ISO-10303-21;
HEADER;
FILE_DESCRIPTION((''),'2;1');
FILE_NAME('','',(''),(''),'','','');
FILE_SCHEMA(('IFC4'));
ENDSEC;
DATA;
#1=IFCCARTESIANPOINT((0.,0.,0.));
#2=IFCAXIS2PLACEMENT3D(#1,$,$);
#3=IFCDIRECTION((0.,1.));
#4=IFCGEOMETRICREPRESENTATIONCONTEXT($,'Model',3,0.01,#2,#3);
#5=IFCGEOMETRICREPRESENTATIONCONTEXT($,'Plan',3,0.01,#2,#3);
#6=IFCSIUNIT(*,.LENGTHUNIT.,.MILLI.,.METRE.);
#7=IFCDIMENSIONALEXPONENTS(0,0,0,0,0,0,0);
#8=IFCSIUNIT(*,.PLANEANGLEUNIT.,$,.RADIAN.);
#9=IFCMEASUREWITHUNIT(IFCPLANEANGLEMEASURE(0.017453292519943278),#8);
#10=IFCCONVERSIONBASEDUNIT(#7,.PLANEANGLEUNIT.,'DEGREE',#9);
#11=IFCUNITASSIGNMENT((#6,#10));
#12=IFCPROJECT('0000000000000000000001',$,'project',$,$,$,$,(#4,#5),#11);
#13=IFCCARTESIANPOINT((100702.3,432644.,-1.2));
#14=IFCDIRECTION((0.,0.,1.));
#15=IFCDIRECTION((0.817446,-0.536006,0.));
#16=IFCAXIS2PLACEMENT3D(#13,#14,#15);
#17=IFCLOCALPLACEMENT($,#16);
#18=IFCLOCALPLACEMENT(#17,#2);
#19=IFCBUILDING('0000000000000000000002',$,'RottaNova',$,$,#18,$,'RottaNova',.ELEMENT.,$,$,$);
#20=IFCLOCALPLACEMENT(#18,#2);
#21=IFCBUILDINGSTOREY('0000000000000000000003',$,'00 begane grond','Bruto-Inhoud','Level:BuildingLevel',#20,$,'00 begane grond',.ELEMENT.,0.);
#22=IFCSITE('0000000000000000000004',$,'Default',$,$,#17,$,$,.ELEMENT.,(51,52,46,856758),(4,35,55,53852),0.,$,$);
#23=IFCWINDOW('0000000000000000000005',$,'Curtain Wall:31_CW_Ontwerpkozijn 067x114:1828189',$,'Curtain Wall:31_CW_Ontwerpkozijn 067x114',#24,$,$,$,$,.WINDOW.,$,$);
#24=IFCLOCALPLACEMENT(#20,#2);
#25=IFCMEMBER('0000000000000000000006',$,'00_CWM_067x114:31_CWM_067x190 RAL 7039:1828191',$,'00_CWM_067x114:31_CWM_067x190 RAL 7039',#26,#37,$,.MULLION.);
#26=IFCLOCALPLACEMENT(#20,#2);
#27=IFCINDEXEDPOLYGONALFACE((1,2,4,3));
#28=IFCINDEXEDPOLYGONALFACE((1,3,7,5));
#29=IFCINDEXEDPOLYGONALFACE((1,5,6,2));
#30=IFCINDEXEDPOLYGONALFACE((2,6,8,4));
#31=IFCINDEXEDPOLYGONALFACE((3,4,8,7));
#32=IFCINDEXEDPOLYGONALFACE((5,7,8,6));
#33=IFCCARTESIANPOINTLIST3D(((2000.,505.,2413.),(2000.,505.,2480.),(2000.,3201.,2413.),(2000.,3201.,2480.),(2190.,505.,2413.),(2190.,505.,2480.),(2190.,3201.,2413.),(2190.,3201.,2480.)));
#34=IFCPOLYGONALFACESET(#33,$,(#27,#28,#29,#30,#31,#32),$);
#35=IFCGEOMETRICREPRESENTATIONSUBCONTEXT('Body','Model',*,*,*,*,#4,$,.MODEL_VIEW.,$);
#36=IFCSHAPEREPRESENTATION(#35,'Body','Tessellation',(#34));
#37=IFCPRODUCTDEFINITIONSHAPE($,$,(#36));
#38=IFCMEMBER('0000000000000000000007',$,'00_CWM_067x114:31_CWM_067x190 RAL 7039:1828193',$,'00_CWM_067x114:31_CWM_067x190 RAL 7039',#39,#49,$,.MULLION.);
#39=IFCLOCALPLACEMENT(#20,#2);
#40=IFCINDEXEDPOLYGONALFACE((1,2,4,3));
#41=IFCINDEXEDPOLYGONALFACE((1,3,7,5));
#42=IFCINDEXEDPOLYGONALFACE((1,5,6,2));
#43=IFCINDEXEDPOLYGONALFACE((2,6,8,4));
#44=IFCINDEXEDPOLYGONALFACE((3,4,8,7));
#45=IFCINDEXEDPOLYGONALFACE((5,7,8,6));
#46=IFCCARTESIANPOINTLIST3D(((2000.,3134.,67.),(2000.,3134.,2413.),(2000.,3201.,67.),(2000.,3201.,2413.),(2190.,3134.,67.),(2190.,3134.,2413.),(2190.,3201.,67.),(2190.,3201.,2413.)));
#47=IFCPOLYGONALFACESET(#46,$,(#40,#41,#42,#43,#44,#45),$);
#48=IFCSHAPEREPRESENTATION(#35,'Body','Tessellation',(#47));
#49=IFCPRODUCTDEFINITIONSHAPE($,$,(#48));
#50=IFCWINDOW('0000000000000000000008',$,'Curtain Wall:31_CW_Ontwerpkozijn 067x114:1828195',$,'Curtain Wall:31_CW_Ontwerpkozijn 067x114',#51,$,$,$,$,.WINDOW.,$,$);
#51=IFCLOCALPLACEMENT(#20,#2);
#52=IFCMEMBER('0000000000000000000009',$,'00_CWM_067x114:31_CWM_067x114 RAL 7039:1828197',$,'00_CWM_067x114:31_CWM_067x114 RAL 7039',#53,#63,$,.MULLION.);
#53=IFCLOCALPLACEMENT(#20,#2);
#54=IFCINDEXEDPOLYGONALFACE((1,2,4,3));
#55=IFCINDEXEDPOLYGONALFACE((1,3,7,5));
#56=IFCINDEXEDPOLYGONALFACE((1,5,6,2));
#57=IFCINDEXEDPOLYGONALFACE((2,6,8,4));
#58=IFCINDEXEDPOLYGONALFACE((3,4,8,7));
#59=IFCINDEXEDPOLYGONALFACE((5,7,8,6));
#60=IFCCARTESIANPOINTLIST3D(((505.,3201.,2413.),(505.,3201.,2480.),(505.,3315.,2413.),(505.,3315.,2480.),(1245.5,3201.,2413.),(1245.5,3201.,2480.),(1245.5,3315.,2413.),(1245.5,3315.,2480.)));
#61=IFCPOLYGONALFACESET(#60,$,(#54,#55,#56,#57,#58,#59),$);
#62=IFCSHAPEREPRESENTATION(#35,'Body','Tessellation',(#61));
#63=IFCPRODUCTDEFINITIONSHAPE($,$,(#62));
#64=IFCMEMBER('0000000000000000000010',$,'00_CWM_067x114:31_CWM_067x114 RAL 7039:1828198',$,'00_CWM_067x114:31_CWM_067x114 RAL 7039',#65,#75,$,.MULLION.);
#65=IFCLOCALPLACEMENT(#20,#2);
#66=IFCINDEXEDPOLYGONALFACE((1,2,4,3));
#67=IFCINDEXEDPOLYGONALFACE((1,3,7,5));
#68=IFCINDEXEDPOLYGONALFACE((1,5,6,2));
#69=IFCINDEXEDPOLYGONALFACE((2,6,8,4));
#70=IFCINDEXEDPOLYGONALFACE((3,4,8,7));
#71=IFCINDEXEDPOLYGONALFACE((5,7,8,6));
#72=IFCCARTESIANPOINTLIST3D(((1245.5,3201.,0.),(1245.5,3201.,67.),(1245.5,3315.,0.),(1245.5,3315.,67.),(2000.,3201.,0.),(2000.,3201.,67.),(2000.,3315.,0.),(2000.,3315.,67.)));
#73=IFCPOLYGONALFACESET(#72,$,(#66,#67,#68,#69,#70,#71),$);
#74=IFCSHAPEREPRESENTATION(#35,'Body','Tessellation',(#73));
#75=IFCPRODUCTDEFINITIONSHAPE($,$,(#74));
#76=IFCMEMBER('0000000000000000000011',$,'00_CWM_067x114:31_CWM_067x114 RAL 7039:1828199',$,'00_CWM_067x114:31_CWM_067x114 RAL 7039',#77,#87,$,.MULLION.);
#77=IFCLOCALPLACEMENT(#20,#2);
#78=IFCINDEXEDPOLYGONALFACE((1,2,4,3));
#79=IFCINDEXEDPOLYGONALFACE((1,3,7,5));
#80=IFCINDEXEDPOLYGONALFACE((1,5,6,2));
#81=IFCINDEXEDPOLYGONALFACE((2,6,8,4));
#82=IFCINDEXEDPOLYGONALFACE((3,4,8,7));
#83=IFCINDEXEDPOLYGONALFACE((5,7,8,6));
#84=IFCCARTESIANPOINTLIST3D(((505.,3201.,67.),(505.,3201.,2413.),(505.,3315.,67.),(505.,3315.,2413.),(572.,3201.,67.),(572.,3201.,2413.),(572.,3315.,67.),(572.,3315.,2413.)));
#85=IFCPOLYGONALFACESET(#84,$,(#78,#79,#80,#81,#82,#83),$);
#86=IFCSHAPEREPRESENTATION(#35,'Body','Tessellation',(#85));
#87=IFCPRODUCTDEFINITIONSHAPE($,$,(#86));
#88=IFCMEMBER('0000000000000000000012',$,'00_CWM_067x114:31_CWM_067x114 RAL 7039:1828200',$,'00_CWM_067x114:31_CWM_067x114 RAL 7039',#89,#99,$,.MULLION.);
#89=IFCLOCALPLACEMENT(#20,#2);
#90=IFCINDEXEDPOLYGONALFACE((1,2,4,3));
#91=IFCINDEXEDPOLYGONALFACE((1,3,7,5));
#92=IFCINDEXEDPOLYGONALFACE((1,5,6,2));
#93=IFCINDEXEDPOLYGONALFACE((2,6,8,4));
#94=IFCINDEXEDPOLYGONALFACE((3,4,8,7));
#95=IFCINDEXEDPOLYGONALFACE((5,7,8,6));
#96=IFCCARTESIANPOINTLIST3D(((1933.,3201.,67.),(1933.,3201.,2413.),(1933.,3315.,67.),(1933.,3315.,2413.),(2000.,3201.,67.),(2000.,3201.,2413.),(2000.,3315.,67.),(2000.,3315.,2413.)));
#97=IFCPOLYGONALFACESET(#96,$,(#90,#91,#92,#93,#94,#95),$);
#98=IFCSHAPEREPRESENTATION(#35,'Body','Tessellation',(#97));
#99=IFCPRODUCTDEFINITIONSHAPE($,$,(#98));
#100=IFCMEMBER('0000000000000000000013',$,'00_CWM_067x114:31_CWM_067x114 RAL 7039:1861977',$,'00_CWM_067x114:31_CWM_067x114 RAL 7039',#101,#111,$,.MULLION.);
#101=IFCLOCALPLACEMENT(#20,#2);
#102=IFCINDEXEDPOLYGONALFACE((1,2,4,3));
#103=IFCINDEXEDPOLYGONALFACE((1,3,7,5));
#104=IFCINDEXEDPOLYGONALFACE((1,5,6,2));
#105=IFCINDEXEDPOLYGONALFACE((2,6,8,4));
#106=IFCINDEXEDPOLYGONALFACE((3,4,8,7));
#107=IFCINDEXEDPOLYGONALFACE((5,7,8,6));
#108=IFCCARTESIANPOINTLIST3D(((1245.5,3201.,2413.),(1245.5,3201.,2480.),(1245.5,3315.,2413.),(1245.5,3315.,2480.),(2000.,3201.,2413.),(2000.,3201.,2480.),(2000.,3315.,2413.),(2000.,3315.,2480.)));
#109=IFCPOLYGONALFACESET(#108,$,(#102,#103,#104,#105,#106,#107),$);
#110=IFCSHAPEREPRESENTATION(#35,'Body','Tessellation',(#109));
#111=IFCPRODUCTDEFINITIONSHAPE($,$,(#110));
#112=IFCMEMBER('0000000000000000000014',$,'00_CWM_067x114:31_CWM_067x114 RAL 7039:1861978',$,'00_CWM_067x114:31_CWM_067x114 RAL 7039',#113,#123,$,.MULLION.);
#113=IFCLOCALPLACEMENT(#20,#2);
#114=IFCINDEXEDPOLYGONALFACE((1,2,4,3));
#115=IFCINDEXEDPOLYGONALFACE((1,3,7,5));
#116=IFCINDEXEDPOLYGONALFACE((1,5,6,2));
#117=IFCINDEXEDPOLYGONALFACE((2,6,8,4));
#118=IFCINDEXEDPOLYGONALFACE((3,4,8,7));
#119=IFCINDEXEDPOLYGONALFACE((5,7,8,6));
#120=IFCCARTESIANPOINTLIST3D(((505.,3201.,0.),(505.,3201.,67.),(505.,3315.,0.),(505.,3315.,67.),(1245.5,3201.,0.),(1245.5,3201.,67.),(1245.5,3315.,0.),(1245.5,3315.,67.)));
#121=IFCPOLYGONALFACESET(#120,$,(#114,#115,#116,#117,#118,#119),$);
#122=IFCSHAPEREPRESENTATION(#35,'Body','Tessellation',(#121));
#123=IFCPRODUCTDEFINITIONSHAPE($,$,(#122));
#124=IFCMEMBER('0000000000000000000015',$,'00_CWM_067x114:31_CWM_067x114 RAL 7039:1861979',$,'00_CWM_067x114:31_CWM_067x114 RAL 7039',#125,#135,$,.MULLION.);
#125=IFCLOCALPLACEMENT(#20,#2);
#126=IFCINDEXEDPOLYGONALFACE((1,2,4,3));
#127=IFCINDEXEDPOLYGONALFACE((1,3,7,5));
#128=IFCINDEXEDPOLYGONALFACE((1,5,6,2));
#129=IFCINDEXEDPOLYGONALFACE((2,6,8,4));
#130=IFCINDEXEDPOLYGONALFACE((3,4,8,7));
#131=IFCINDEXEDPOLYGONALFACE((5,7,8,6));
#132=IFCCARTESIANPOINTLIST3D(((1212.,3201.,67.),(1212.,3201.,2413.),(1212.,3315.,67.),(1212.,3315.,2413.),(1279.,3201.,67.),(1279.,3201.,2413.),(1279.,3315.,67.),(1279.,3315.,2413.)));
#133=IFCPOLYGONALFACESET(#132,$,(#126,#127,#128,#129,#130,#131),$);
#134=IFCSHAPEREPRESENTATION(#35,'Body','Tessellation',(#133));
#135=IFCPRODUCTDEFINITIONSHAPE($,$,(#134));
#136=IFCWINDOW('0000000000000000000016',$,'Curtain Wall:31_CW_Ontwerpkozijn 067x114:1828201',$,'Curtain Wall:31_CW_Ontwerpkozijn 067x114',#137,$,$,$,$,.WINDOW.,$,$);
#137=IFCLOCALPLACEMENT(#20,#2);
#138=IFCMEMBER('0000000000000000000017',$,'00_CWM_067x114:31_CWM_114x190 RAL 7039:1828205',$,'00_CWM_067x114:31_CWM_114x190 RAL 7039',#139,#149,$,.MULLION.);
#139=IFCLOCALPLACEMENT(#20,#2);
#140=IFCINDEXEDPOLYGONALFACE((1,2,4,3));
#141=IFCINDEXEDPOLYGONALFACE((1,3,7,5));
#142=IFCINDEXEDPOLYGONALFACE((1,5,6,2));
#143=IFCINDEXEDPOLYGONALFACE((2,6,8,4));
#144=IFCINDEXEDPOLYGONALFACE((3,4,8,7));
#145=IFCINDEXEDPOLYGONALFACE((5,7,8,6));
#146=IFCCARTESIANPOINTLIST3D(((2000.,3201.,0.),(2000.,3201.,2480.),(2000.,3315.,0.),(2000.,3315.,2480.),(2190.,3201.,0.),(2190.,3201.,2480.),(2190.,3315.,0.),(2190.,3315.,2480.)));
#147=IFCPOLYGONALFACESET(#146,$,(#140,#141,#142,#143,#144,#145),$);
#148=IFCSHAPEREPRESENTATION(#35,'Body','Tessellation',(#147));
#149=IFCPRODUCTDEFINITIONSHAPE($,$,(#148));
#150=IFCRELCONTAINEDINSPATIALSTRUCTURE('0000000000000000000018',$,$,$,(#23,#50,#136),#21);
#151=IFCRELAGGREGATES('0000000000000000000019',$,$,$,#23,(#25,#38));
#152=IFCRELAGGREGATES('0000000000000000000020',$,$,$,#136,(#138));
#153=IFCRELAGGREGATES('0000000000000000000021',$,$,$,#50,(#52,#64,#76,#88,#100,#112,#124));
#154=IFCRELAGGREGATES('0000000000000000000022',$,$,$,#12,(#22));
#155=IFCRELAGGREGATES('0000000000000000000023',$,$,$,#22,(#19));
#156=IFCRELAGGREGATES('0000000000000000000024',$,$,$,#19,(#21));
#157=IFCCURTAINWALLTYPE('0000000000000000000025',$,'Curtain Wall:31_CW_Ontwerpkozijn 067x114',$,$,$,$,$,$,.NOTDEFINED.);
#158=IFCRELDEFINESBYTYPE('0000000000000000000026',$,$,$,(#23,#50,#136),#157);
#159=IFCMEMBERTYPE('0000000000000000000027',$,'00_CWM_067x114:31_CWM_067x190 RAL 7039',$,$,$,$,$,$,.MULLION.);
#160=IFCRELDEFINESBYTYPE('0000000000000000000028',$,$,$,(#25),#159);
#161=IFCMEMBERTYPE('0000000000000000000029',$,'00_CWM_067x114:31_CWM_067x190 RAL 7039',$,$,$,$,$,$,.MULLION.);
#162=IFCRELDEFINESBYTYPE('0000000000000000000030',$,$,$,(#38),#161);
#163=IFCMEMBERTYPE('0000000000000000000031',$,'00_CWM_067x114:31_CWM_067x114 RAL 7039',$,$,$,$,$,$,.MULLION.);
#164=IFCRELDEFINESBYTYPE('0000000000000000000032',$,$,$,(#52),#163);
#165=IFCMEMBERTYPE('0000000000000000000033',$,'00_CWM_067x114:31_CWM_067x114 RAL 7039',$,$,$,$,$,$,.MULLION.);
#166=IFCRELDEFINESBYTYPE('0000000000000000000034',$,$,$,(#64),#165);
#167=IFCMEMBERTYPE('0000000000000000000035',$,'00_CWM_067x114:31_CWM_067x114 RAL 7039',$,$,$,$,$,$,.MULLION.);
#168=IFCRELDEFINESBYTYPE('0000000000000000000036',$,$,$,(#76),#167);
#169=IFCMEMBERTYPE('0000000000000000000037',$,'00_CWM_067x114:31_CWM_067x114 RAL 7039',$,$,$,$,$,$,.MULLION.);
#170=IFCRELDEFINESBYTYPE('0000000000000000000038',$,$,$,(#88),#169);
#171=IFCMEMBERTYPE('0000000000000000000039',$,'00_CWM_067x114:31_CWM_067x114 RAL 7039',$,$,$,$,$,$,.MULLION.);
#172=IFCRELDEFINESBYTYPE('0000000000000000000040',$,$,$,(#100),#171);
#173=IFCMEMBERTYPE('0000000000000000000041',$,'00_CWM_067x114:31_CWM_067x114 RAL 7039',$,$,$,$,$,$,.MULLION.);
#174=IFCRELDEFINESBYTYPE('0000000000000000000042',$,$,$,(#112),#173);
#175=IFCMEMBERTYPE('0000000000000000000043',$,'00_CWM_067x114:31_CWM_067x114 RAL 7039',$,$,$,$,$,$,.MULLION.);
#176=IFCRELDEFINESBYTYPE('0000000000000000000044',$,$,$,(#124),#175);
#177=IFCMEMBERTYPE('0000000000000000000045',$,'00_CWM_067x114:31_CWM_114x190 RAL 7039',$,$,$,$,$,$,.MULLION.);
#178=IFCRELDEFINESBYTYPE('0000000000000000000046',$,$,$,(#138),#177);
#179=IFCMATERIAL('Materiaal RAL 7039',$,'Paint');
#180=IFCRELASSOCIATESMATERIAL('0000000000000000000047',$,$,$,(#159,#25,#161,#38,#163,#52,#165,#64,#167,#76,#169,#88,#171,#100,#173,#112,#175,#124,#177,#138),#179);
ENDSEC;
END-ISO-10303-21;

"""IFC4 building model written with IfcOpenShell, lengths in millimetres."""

from ifc_helpers import new_model, entity, si_unit, converted_unit, direction, frame, origin, place, context, subcontext, project, spatial, indexed_curve, outline, extrude, source, transform, mapped, material, type_object, type_shapes, element, aggregate, save


model = new_model("IFC4")

# Units and contexts
model_context = context("Model", 3, precision=0.01, world=origin(), true_north=direction((0.0, 1.0)))
plan_context = context("Plan", 3, precision=0.01, world=origin(), true_north=direction((0.0, 1.0)))
body_context = subcontext(model_context, "Body", "Model", "MODEL_VIEW")
ifc_project = project(units=[si_unit("LENGTHUNIT", "METRE", prefix="MILLI"), converted_unit("PLANEANGLEUNIT", "DEGREE", entity("IfcPlaneAngleMeasure", 0.017453292519943278), si_unit("PLANEANGLEUNIT", "RADIAN"), dimensions=[0, 0, 0, 0, 0, 0, 0])], contexts=[model_context, plan_context])

# Site, building, storey
site_placement = place(None, frame((100702.3, 432644.0, -1.2), z_axis=(0.0, 0.0, 1.0), x_axis=(0.817446, -0.536006, 0.0)))
site = spatial("IfcSite", under=ifc_project, at=site_placement, Name="Default", CompositionType="ELEMENT", RefLatitude=(51, 52, 46, 856758), RefLongitude=(4, 35, 55, 53852), RefElevation=0.0)
building_placement = place(site_placement, origin())
building = spatial("IfcBuilding", under=site, at=building_placement, Name="RottaNova", LongName="RottaNova", CompositionType="ELEMENT")
storey_placement = place(building_placement, origin())
storey = spatial("IfcBuildingStorey", under=building, at=storey_placement, Name="00 begane grond", Description="Bruto-Inhoud", ObjectType="Level:BuildingLevel", LongName="00 begane grond", CompositionType="ELEMENT", Elevation=0.0)

# Windows, members
curtain_wall_type = type_object("IfcCurtainWallType", Name="Curtain Wall:31_CW_Ontwerpkozijn 067x114", PredefinedType="NOTDEFINED")
window_1_placement = place(storey_placement, origin())
window_1 = element("IfcWindow", 1, at=window_1_placement, inside=storey, type_object=curtain_wall_type, Name="Curtain Wall:31_CW_Ontwerpkozijn 067x114:1828189", ObjectType="Curtain Wall:31_CW_Ontwerpkozijn 067x114", PredefinedType="WINDOW")
ifc_material_1 = material(Name="Materiaal RAL 7039", Category="Paint")
member_type_1 = type_object("IfcMemberType", Name="00_CWM_067x114:31_CWM_067x190 RAL 7039", PredefinedType="MULLION", material=ifc_material_1)
shared_shape_1 = source(origin(), body_context, "Body", "SweptSolid", [
    extrude(outline(indexed_curve([(-33.5, -95.0), (33.5, -95.0), (33.5, 95.0), (-33.5, 95.0), (-33.5, -95.0)], self_intersect=False)), frame((-33.5, -95.0, -2696.0), z_axis=(0.0, 0.0, 1.0), x_axis=(-1.0, 0.0, 0.0)), (0.0, 0.0, 1.0), 2696.0),
])
type_shapes(member_type_1, [shared_shape_1])
member_1_placement = place(window_1_placement, frame((2190.0, 3201.0, 2480.0), z_axis=(0.0, 1.0, 0.0), x_axis=(0.0, 0.0, 1.0)))
member_1 = element("IfcMember", 2, at=member_1_placement, type_object=member_type_1, material=ifc_material_1, Name="00_CWM_067x114:31_CWM_067x190 RAL 7039:1828191", ObjectType="00_CWM_067x114:31_CWM_067x190 RAL 7039", PredefinedType="MULLION", context=body_context, shape_type="MappedRepresentation", body=[
    mapped(shared_shape_1, transform((0.0, 0.0, 0.0), scale=1.0)),
])
member_type_2 = type_object("IfcMemberType", Name="00_CWM_067x114:31_CWM_067x190 RAL 7039", PredefinedType="MULLION", material=ifc_material_1)
shared_shape_2 = source(origin(), body_context, "Body", "SweptSolid", [
    extrude(outline(indexed_curve([(-33.5, -95.0), (33.5, -95.0), (33.5, 95.0), (-33.5, 95.0), (-33.5, -95.0)], self_intersect=False)), frame((-33.5, -95.0, -2346.0), z_axis=(0.0, 0.0, 1.0), x_axis=(-1.0, 0.0, 0.0)), (0.0, 0.0, 1.0), 2346.0),
])
type_shapes(member_type_2, [shared_shape_2])
member_2_placement = place(window_1_placement, frame((2190.0, 3201.0, 67.0), z_axis=(0.0, 0.0, -1.0), x_axis=(0.0, 1.0, 0.0)))
member_2 = element("IfcMember", 3, at=member_2_placement, type_object=member_type_2, material=ifc_material_1, Name="00_CWM_067x114:31_CWM_067x190 RAL 7039:1828193", ObjectType="00_CWM_067x114:31_CWM_067x190 RAL 7039", PredefinedType="MULLION", context=body_context, shape_type="MappedRepresentation", body=[
    mapped(shared_shape_2, transform((0.0, 0.0, 0.0), scale=1.0)),
])
aggregate(window_1, [member_1, member_2])
window_2_placement = place(storey_placement, origin())
window_2 = element("IfcWindow", 4, at=window_2_placement, inside=storey, type_object=curtain_wall_type, Name="Curtain Wall:31_CW_Ontwerpkozijn 067x114:1828195", ObjectType="Curtain Wall:31_CW_Ontwerpkozijn 067x114", PredefinedType="WINDOW")
member_type_3 = type_object("IfcMemberType", Name="00_CWM_067x114:31_CWM_067x114 RAL 7039", PredefinedType="MULLION", material=ifc_material_1)
shared_shape_3 = source(origin(), body_context, "Body", "SweptSolid", [
    extrude(outline(indexed_curve([(-33.5, -57.0), (33.5, -57.0), (33.5, 57.0), (-33.5, 57.0), (-33.5, -57.0)], self_intersect=False)), frame((-33.5, -57.0, -740.5), z_axis=(0.0, 0.0, 1.0), x_axis=(-1.0, 0.0, 0.0)), (0.0, 0.0, 1.0), 740.5),
])
type_shapes(member_type_3, [shared_shape_3])
member_3_placement = place(window_2_placement, frame((505.0, 3315.0, 2480.0), z_axis=(-1.0, 0.0, 0.0), x_axis=(0.0, 0.0, 1.0)))
member_3 = element("IfcMember", 5, at=member_3_placement, type_object=member_type_3, material=ifc_material_1, Name="00_CWM_067x114:31_CWM_067x114 RAL 7039:1828197", ObjectType="00_CWM_067x114:31_CWM_067x114 RAL 7039", PredefinedType="MULLION", context=body_context, shape_type="MappedRepresentation", body=[
    mapped(shared_shape_3, transform((0.0, 0.0, 0.0), scale=1.0)),
])
member_type_4 = type_object("IfcMemberType", Name="00_CWM_067x114:31_CWM_067x114 RAL 7039", PredefinedType="MULLION", material=ifc_material_1)
shared_shape_4 = source(origin(), body_context, "Body", "SweptSolid", [
    extrude(outline(indexed_curve([(-33.5, -57.0), (33.5, -57.0), (33.5, 57.0), (-33.5, 57.0), (-33.5, -57.0)], self_intersect=False)), frame((-33.5, -57.0, -754.5), z_axis=(0.0, 0.0, 1.0), x_axis=(-1.0, 0.0, 0.0)), (0.0, 0.0, 1.0), 754.5),
])
type_shapes(member_type_4, [shared_shape_4])
member_4_placement = place(window_2_placement, frame((2000.0, 3315.0, 0.0), z_axis=(1.0, 0.0, 0.0), x_axis=(0.0, 0.0, -1.0)))
member_4 = element("IfcMember", 6, at=member_4_placement, type_object=member_type_4, material=ifc_material_1, Name="00_CWM_067x114:31_CWM_067x114 RAL 7039:1828198", ObjectType="00_CWM_067x114:31_CWM_067x114 RAL 7039", PredefinedType="MULLION", context=body_context, shape_type="MappedRepresentation", body=[
    mapped(shared_shape_4, transform((0.0, 0.0, 0.0), scale=1.0)),
])
member_type_5 = type_object("IfcMemberType", Name="00_CWM_067x114:31_CWM_067x114 RAL 7039", PredefinedType="MULLION", material=ifc_material_1)
shared_shape_5 = source(origin(), body_context, "Body", "SweptSolid", [
    extrude(outline(indexed_curve([(-33.5, -57.0), (33.5, -57.0), (33.5, 57.0), (-33.5, 57.0), (-33.5, -57.0)], self_intersect=False)), frame((-33.5, -57.0, -2346.0), z_axis=(0.0, 0.0, 1.0), x_axis=(-1.0, 0.0, 0.0)), (0.0, 0.0, 1.0), 2346.0),
])
type_shapes(member_type_5, [shared_shape_5])
member_5_placement = place(window_2_placement, frame((505.0, 3315.0, 67.0), z_axis=(0.0, 0.0, -1.0), x_axis=(-1.0, 0.0, 0.0)))
member_5 = element("IfcMember", 7, at=member_5_placement, type_object=member_type_5, material=ifc_material_1, Name="00_CWM_067x114:31_CWM_067x114 RAL 7039:1828199", ObjectType="00_CWM_067x114:31_CWM_067x114 RAL 7039", PredefinedType="MULLION", context=body_context, shape_type="MappedRepresentation", body=[
    mapped(shared_shape_5, transform((0.0, 0.0, 0.0), scale=1.0)),
])
member_type_6 = type_object("IfcMemberType", Name="00_CWM_067x114:31_CWM_067x114 RAL 7039", PredefinedType="MULLION", material=ifc_material_1)
shared_shape_6 = source(origin(), body_context, "Body", "SweptSolid", [
    extrude(outline(indexed_curve([(-33.5, -57.0), (33.5, -57.0), (33.5, 57.0), (-33.5, 57.0), (-33.5, -57.0)], self_intersect=False)), frame((-33.5, -57.0, -2346.0), z_axis=(0.0, 0.0, 1.0), x_axis=(-1.0, 0.0, 0.0)), (0.0, 0.0, 1.0), 2346.0),
])
type_shapes(member_type_6, [shared_shape_6])
member_6_placement = place(window_2_placement, frame((2000.0, 3315.0, 2413.0)))
member_6 = element("IfcMember", 8, at=member_6_placement, type_object=member_type_6, material=ifc_material_1, Name="00_CWM_067x114:31_CWM_067x114 RAL 7039:1828200", ObjectType="00_CWM_067x114:31_CWM_067x114 RAL 7039", PredefinedType="MULLION", context=body_context, shape_type="MappedRepresentation", body=[
    mapped(shared_shape_6, transform((0.0, 0.0, 0.0), scale=1.0)),
])
member_type_7 = type_object("IfcMemberType", Name="00_CWM_067x114:31_CWM_067x114 RAL 7039", PredefinedType="MULLION", material=ifc_material_1)
shared_shape_7 = source(origin(), body_context, "Body", "SweptSolid", [
    extrude(outline(indexed_curve([(-33.5, -57.0), (33.5, -57.0), (33.5, 57.0), (-33.5, 57.0), (-33.5, -57.0)], self_intersect=False)), frame((-33.5, -57.0, -754.5), z_axis=(0.0, 0.0, 1.0), x_axis=(-1.0, 0.0, 0.0)), (0.0, 0.0, 1.0), 754.5),
])
type_shapes(member_type_7, [shared_shape_7])
member_7_placement = place(window_2_placement, frame((1245.5, 3315.0, 2480.0), z_axis=(-1.0, 0.0, 0.0), x_axis=(0.0, 0.0, 1.0)))
member_7 = element("IfcMember", 9, at=member_7_placement, type_object=member_type_7, material=ifc_material_1, Name="00_CWM_067x114:31_CWM_067x114 RAL 7039:1861977", ObjectType="00_CWM_067x114:31_CWM_067x114 RAL 7039", PredefinedType="MULLION", context=body_context, shape_type="MappedRepresentation", body=[
    mapped(shared_shape_7, transform((0.0, 0.0, 0.0), scale=1.0)),
])
member_type_8 = type_object("IfcMemberType", Name="00_CWM_067x114:31_CWM_067x114 RAL 7039", PredefinedType="MULLION", material=ifc_material_1)
shared_shape_8 = source(origin(), body_context, "Body", "SweptSolid", [
    extrude(outline(indexed_curve([(-33.5, -57.0), (33.5, -57.0), (33.5, 57.0), (-33.5, 57.0), (-33.5, -57.0)], self_intersect=False)), frame((-33.5, -57.0, -740.5), z_axis=(0.0, 0.0, 1.0), x_axis=(-1.0, 0.0, 0.0)), (0.0, 0.0, 1.0), 740.5),
])
type_shapes(member_type_8, [shared_shape_8])
member_8_placement = place(window_2_placement, frame((1245.5, 3315.0, 0.0), z_axis=(1.0, 0.0, 0.0), x_axis=(0.0, 0.0, -1.0)))
member_8 = element("IfcMember", 10, at=member_8_placement, type_object=member_type_8, material=ifc_material_1, Name="00_CWM_067x114:31_CWM_067x114 RAL 7039:1861978", ObjectType="00_CWM_067x114:31_CWM_067x114 RAL 7039", PredefinedType="MULLION", context=body_context, shape_type="MappedRepresentation", body=[
    mapped(shared_shape_8, transform((0.0, 0.0, 0.0), scale=1.0)),
])
member_type_9 = type_object("IfcMemberType", Name="00_CWM_067x114:31_CWM_067x114 RAL 7039", PredefinedType="MULLION", material=ifc_material_1)
shared_shape_9 = source(origin(), body_context, "Body", "SweptSolid", [
    extrude(outline(indexed_curve([(-33.5, -57.0), (33.5, -57.0), (33.5, 57.0), (-33.5, 57.0), (-33.5, -57.0)], self_intersect=False)), frame((0.0, -57.0, -2346.0), z_axis=(0.0, 0.0, 1.0), x_axis=(-1.0, 0.0, 0.0)), (0.0, 0.0, 1.0), 2346.0),
])
type_shapes(member_type_9, [shared_shape_9])
member_9_placement = place(window_2_placement, frame((1245.5, 3315.0, 67.0), z_axis=(0.0, 0.0, -1.0), x_axis=(-1.0, 0.0, 0.0)))
member_9 = element("IfcMember", 11, at=member_9_placement, type_object=member_type_9, material=ifc_material_1, Name="00_CWM_067x114:31_CWM_067x114 RAL 7039:1861979", ObjectType="00_CWM_067x114:31_CWM_067x114 RAL 7039", PredefinedType="MULLION", context=body_context, shape_type="MappedRepresentation", body=[
    mapped(shared_shape_9, transform((0.0, 0.0, 0.0), scale=1.0)),
])

# Window, member
window_3_placement = place(storey_placement, origin())
window_3 = element("IfcWindow", 12, at=window_3_placement, inside=storey, type_object=curtain_wall_type, Name="Curtain Wall:31_CW_Ontwerpkozijn 067x114:1828201", ObjectType="Curtain Wall:31_CW_Ontwerpkozijn 067x114", PredefinedType="WINDOW")
member_type_10 = type_object("IfcMemberType", Name="00_CWM_067x114:31_CWM_114x190 RAL 7039", PredefinedType="MULLION", material=ifc_material_1)
shared_shape_10 = source(origin(), body_context, "Body", "SweptSolid", [
    extrude(outline(indexed_curve([(-95.0, -57.0), (95.0, -57.0), (95.0, 57.0), (-95.0, 57.0), (-95.0, -57.0)], self_intersect=False)), frame((-95.0, 0.0, -2480.0)), (0.0, 0.0, 1.0), 2480.0),
])
type_shapes(member_type_10, [shared_shape_10])
member_10_placement = place(window_3_placement, frame((2190.0, 3258.0, 2480.0)))
member_10 = element("IfcMember", 13, at=member_10_placement, type_object=member_type_10, material=ifc_material_1, Name="00_CWM_067x114:31_CWM_114x190 RAL 7039:1828205", ObjectType="00_CWM_067x114:31_CWM_114x190 RAL 7039", PredefinedType="MULLION", context=body_context, shape_type="MappedRepresentation", body=[
    mapped(shared_shape_10, transform((0.0, 0.0, 0.0), scale=1.0)),
])
aggregate(window_3, [member_10])

aggregate(window_2, [member_3, member_4, member_5, member_6, member_7, member_8, member_9])

save(model, "model.ifc")
